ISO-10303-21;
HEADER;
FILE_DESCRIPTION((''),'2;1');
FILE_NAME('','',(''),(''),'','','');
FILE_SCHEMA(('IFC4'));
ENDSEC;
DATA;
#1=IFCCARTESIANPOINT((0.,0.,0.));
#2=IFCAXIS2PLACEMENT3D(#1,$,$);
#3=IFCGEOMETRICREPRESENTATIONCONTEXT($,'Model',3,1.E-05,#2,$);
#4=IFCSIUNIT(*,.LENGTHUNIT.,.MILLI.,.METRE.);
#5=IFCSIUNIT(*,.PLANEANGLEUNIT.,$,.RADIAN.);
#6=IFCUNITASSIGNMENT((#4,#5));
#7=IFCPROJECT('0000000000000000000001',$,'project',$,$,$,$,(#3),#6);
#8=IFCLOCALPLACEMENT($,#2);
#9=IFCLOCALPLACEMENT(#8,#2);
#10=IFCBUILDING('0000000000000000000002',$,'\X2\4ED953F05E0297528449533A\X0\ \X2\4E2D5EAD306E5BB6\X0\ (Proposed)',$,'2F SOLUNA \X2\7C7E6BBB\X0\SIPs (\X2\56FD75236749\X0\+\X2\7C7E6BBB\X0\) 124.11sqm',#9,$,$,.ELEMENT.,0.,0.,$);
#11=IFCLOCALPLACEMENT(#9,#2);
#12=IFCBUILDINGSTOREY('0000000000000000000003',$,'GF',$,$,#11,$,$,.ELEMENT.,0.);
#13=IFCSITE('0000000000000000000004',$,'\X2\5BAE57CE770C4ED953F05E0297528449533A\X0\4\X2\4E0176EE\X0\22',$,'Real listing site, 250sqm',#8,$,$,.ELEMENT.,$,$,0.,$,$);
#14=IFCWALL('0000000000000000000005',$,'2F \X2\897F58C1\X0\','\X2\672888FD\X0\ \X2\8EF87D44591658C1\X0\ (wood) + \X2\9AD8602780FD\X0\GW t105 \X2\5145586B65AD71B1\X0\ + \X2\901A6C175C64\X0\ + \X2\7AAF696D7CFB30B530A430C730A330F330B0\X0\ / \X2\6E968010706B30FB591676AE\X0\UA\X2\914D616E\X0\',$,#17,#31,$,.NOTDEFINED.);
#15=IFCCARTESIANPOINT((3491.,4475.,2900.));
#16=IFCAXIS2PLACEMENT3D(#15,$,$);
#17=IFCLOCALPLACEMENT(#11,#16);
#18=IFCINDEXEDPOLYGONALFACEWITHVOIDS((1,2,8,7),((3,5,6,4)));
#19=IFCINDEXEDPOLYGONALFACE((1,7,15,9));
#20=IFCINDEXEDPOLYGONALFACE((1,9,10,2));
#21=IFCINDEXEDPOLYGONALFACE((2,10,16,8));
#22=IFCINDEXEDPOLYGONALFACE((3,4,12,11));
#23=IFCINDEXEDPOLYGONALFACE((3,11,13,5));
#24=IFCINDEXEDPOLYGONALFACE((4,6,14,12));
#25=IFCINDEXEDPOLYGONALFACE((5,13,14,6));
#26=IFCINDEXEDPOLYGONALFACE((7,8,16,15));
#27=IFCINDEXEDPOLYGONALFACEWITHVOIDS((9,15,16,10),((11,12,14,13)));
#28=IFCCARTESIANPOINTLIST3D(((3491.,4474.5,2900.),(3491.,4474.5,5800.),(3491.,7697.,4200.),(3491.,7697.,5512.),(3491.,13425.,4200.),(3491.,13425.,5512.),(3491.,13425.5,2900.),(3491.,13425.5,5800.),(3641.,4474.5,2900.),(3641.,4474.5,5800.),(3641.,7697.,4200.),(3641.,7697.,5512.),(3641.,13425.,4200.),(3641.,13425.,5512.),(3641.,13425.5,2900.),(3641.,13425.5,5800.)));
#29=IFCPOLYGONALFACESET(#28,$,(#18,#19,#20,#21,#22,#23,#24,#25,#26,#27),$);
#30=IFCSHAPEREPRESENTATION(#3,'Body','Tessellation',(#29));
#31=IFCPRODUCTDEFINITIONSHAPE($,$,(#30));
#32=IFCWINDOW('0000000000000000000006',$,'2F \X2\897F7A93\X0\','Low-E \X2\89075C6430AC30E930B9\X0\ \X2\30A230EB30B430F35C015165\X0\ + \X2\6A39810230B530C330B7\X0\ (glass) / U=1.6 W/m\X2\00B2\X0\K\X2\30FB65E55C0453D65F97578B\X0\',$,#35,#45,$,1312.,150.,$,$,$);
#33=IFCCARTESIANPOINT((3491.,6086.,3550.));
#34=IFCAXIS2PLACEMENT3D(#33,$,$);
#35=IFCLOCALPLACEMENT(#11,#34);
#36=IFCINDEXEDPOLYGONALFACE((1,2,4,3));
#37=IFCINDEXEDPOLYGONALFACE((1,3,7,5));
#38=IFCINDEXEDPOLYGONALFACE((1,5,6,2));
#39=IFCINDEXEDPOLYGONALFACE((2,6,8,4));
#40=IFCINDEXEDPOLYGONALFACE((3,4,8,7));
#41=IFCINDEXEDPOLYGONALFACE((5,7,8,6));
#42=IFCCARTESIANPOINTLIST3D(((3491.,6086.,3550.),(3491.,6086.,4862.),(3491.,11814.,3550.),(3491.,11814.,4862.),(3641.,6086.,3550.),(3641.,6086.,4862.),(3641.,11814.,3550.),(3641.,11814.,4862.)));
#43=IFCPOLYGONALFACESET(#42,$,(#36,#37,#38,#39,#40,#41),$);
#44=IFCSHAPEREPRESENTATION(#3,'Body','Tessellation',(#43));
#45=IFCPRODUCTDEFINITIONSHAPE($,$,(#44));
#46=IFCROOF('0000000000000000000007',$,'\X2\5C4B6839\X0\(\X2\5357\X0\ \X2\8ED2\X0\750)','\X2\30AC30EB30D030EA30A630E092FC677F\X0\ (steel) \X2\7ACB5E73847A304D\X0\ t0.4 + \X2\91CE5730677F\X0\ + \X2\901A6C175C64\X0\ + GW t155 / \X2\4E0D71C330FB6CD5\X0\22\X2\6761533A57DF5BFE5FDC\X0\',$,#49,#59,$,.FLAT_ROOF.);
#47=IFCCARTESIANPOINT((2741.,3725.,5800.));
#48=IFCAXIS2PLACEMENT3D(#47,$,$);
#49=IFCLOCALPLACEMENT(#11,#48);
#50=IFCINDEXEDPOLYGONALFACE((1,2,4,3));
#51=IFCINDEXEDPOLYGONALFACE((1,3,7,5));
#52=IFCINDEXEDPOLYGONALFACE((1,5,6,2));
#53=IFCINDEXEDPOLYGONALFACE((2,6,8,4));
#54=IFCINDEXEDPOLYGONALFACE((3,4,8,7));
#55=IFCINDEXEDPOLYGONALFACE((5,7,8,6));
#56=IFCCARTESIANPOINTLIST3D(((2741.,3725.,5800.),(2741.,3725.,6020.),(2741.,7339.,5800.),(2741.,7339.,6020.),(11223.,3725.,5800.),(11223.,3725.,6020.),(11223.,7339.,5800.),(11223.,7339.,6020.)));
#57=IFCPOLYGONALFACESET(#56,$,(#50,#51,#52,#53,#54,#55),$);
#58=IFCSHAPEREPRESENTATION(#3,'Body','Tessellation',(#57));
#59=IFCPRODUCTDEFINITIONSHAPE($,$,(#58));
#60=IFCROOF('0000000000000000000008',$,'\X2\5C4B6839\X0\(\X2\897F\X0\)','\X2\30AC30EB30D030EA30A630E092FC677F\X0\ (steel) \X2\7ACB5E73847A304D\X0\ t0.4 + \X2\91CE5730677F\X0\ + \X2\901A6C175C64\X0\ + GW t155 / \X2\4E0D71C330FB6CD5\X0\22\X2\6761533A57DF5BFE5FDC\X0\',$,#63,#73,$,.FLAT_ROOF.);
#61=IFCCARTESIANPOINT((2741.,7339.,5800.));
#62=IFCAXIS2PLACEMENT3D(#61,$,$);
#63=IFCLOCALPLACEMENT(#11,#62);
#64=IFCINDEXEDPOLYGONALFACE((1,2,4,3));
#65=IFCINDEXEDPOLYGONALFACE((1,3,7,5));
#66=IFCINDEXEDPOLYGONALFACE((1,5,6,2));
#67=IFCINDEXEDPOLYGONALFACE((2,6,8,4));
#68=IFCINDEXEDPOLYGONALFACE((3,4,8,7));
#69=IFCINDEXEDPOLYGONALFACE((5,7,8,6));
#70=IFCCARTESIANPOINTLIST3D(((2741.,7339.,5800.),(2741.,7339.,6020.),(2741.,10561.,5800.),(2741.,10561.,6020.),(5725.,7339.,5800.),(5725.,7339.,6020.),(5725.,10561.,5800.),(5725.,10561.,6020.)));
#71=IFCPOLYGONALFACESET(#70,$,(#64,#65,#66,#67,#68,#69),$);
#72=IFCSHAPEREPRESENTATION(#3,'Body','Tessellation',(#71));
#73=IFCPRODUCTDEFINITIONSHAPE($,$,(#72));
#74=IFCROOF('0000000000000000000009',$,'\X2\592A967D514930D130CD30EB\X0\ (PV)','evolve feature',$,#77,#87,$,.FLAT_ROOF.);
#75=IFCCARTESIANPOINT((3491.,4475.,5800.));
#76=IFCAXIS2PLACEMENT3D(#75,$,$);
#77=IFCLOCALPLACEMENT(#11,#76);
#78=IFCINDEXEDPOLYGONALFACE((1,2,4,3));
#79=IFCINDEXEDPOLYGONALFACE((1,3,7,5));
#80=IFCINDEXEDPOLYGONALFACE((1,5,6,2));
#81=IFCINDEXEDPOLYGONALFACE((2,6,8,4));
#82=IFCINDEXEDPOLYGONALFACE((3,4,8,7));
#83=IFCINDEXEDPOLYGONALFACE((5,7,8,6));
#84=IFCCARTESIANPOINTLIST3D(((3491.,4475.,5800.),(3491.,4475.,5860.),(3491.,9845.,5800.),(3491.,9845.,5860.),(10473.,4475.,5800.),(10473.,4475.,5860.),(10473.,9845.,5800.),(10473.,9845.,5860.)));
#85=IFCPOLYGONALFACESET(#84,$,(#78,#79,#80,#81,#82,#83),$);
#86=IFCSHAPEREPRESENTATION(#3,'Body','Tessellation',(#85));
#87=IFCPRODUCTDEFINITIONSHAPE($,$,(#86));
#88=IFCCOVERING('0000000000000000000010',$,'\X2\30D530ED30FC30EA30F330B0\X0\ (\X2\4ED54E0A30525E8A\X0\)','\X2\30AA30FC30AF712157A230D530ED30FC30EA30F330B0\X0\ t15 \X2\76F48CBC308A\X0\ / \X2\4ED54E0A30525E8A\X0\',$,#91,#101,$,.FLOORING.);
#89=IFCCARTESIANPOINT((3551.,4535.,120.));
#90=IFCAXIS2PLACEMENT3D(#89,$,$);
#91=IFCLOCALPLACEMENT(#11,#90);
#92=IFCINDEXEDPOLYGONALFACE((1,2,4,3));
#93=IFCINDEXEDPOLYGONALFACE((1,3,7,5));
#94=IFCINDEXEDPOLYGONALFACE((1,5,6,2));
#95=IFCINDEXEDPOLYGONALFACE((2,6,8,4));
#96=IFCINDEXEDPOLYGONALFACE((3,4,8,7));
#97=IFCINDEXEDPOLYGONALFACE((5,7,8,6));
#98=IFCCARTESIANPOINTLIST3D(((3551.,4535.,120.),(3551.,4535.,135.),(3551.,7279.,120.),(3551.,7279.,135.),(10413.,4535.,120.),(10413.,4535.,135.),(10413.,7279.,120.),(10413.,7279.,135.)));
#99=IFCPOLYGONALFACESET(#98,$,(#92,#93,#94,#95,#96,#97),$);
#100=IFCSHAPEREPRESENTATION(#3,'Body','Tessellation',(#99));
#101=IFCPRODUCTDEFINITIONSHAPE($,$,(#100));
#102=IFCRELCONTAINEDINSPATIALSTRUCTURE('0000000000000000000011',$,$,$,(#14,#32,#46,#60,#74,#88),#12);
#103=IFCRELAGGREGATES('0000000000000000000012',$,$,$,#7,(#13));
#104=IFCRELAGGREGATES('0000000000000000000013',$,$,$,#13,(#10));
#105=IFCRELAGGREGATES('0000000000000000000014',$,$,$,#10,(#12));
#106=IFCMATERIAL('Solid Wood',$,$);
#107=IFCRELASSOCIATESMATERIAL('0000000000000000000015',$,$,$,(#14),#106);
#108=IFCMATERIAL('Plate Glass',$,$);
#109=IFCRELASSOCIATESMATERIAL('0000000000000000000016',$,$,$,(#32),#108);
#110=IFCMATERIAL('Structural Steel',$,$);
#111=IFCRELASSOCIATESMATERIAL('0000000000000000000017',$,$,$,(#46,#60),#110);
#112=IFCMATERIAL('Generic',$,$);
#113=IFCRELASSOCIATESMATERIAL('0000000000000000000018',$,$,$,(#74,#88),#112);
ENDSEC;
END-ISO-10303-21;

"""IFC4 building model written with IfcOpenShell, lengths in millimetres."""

from ifc_helpers import new_model, si_unit, frame, frame_2d, origin, place, context, project, spatial, rectangle, extrude, material, element, fill, save


model = new_model("IFC4")

# Units and contexts
model_context = context("Model", 3, precision=1e-05, world=origin())
ifc_project = project(units=[si_unit("LENGTHUNIT", "METRE", prefix="MILLI"), si_unit("PLANEANGLEUNIT", "RADIAN")], contexts=[model_context])

# Site, building, storey
site_placement = place(None, origin())
site = spatial("IfcSite", under=ifc_project, at=site_placement, Name="宮城県仙台市青葉区4丁目22", ObjectType="Real listing site, 250sqm", CompositionType="ELEMENT", RefElevation=0.0)
building_placement = place(site_placement, origin())
building = spatial("IfcBuilding", under=site, at=building_placement, Name="仙台市青葉区 中庭の家 (Proposed)", ObjectType="2F SOLUNA 籾殻SIPs (国産杉+籾殻) 124.11sqm", CompositionType="ELEMENT", ElevationOfRefHeight=0.0, ElevationOfTerrain=0.0)
storey_placement = place(building_placement, origin())
storey = spatial("IfcBuildingStorey", under=building, at=storey_placement, Name="GF", CompositionType="ELEMENT", Elevation=0.0)

# Shared definitions
ifc_material_1 = material(Name="Solid Wood")
ifc_material_2 = material(Name="Generic")

# Shared definitions
ifc_material_3 = material(Name="Plate Glass")

# Wall, opening, window
wall_1_placement = place(storey_placement, frame((3491.0, 4475.0, 2900.0)))
wall_1 = element("IfcWall", 1, at=wall_1_placement, inside=storey, material=ifc_material_1, Name="2F 西壁", Description="木製 軸組外壁 (wood) + 高性能GW t105 充填断熱 + 通気層 + 窯業系サイディング / 準耐火・外皮UA配慮", PredefinedType="NOTDEFINED", context=model_context, shape_type="SweptSolid", body=[
    extrude(rectangle(XDim=150.0, YDim=8951.0, at=frame_2d((75.0, 4475.0))), frame((3491.0, 4475.0, 2900.0)), (0.0, 0.0, 1.0), 2900.0),
])
opening_1_placement = place(storey_placement, frame((3491.0, 6086.0, 3550.0)))
opening_1 = element("IfcOpeningElement", 2, at=opening_1_placement, cuts=wall_1, PredefinedType="NOTDEFINED", context=model_context, shape_type="SweptSolid", body=[
    extrude(rectangle(XDim=150.0, YDim=5728.0, at=frame_2d((75.0, 2864.0))), frame((3491.0, 6086.0, 3550.0)), (0.0, 0.0, 1.0), 1312.0),
])
window_1_placement = place(storey_placement, frame((3491.0, 6086.0, 3550.0)))
window_1 = element("IfcWindow", 3, at=window_1_placement, inside=storey, material=ifc_material_3, Name="2F 西窓", Description="Low-E 複層ガラス アルゴン封入 + 樹脂サッシ (glass) / U=1.6 W/m²K・日射取得型", OverallHeight=1312.0, OverallWidth=150.0, context=model_context, shape_type="SweptSolid", body=[
    extrude(rectangle(XDim=150.0, YDim=5728.0, at=frame_2d((75.0, 2864.0))), frame((3491.0, 6086.0, 3550.0)), (0.0, 0.0, 1.0), 1312.0),
])
fill(opening_1, window_1)

# Roofs
ifc_material_4 = material(Name="Structural Steel")
roof_1_placement = place(storey_placement, frame((2741.0, 3725.0, 5800.0)))
element("IfcRoof", 4, at=roof_1_placement, inside=storey, material=ifc_material_4, Name="屋根(南 軒750)", Description="ガルバリウム鋼板 (steel) 立平葺き t0.4 + 野地板 + 通気層 + GW t155 / 不燃・法22条区域対応", PredefinedType="FLAT_ROOF", context=model_context, shape_type="SweptSolid", body=[
    extrude(rectangle(XDim=8482.0, YDim=3614.0, at=frame_2d((4241.0, 1807.0))), frame((2741.0, 3725.0, 5800.0)), (0.0, 0.0, 1.0), 220.0),
])
roof_2_placement = place(storey_placement, frame((2741.0, 7339.0, 5800.0)))
element("IfcRoof", 5, at=roof_2_placement, inside=storey, material=ifc_material_4, Name="屋根(西)", Description="ガルバリウム鋼板 (steel) 立平葺き t0.4 + 野地板 + 通気層 + GW t155 / 不燃・法22条区域対応", PredefinedType="FLAT_ROOF", context=model_context, shape_type="SweptSolid", body=[
    extrude(rectangle(XDim=2984.0, YDim=3222.0, at=frame_2d((1492.0, 1611.0))), frame((2741.0, 7339.0, 5800.0)), (0.0, 0.0, 1.0), 220.0),
])
roof_3_placement = place(storey_placement, frame((3491.0, 4475.0, 5800.0)))
element("IfcRoof", 6, at=roof_3_placement, inside=storey, material=ifc_material_2, Name="太陽光パネル (PV)", Description="evolve feature", PredefinedType="FLAT_ROOF", context=model_context, shape_type="SweptSolid", body=[
    extrude(rectangle(XDim=6982.0, YDim=5370.0, at=frame_2d((3491.0, 2685.0))), frame((3491.0, 4475.0, 5800.0)), (0.0, 0.0, 1.0), 60.0),
])

# Covering
covering_placement = place(storey_placement, frame((3551.0, 4535.0, 120.0)))
element("IfcCovering", 7, at=covering_placement, inside=storey, material=ifc_material_2, Name="フローリング (仕上げ床)", Description="オーク無垢フローリング t15 直貼り / 仕上げ床", PredefinedType="FLOORING", context=model_context, shape_type="SweptSolid", body=[
    extrude(rectangle(XDim=6862.0, YDim=2744.0, at=frame_2d((3431.0, 1372.0))), frame((3551.0, 4535.0, 120.0)), (0.0, 0.0, 1.0), 15.0),
])

save(model, "model.ifc")
